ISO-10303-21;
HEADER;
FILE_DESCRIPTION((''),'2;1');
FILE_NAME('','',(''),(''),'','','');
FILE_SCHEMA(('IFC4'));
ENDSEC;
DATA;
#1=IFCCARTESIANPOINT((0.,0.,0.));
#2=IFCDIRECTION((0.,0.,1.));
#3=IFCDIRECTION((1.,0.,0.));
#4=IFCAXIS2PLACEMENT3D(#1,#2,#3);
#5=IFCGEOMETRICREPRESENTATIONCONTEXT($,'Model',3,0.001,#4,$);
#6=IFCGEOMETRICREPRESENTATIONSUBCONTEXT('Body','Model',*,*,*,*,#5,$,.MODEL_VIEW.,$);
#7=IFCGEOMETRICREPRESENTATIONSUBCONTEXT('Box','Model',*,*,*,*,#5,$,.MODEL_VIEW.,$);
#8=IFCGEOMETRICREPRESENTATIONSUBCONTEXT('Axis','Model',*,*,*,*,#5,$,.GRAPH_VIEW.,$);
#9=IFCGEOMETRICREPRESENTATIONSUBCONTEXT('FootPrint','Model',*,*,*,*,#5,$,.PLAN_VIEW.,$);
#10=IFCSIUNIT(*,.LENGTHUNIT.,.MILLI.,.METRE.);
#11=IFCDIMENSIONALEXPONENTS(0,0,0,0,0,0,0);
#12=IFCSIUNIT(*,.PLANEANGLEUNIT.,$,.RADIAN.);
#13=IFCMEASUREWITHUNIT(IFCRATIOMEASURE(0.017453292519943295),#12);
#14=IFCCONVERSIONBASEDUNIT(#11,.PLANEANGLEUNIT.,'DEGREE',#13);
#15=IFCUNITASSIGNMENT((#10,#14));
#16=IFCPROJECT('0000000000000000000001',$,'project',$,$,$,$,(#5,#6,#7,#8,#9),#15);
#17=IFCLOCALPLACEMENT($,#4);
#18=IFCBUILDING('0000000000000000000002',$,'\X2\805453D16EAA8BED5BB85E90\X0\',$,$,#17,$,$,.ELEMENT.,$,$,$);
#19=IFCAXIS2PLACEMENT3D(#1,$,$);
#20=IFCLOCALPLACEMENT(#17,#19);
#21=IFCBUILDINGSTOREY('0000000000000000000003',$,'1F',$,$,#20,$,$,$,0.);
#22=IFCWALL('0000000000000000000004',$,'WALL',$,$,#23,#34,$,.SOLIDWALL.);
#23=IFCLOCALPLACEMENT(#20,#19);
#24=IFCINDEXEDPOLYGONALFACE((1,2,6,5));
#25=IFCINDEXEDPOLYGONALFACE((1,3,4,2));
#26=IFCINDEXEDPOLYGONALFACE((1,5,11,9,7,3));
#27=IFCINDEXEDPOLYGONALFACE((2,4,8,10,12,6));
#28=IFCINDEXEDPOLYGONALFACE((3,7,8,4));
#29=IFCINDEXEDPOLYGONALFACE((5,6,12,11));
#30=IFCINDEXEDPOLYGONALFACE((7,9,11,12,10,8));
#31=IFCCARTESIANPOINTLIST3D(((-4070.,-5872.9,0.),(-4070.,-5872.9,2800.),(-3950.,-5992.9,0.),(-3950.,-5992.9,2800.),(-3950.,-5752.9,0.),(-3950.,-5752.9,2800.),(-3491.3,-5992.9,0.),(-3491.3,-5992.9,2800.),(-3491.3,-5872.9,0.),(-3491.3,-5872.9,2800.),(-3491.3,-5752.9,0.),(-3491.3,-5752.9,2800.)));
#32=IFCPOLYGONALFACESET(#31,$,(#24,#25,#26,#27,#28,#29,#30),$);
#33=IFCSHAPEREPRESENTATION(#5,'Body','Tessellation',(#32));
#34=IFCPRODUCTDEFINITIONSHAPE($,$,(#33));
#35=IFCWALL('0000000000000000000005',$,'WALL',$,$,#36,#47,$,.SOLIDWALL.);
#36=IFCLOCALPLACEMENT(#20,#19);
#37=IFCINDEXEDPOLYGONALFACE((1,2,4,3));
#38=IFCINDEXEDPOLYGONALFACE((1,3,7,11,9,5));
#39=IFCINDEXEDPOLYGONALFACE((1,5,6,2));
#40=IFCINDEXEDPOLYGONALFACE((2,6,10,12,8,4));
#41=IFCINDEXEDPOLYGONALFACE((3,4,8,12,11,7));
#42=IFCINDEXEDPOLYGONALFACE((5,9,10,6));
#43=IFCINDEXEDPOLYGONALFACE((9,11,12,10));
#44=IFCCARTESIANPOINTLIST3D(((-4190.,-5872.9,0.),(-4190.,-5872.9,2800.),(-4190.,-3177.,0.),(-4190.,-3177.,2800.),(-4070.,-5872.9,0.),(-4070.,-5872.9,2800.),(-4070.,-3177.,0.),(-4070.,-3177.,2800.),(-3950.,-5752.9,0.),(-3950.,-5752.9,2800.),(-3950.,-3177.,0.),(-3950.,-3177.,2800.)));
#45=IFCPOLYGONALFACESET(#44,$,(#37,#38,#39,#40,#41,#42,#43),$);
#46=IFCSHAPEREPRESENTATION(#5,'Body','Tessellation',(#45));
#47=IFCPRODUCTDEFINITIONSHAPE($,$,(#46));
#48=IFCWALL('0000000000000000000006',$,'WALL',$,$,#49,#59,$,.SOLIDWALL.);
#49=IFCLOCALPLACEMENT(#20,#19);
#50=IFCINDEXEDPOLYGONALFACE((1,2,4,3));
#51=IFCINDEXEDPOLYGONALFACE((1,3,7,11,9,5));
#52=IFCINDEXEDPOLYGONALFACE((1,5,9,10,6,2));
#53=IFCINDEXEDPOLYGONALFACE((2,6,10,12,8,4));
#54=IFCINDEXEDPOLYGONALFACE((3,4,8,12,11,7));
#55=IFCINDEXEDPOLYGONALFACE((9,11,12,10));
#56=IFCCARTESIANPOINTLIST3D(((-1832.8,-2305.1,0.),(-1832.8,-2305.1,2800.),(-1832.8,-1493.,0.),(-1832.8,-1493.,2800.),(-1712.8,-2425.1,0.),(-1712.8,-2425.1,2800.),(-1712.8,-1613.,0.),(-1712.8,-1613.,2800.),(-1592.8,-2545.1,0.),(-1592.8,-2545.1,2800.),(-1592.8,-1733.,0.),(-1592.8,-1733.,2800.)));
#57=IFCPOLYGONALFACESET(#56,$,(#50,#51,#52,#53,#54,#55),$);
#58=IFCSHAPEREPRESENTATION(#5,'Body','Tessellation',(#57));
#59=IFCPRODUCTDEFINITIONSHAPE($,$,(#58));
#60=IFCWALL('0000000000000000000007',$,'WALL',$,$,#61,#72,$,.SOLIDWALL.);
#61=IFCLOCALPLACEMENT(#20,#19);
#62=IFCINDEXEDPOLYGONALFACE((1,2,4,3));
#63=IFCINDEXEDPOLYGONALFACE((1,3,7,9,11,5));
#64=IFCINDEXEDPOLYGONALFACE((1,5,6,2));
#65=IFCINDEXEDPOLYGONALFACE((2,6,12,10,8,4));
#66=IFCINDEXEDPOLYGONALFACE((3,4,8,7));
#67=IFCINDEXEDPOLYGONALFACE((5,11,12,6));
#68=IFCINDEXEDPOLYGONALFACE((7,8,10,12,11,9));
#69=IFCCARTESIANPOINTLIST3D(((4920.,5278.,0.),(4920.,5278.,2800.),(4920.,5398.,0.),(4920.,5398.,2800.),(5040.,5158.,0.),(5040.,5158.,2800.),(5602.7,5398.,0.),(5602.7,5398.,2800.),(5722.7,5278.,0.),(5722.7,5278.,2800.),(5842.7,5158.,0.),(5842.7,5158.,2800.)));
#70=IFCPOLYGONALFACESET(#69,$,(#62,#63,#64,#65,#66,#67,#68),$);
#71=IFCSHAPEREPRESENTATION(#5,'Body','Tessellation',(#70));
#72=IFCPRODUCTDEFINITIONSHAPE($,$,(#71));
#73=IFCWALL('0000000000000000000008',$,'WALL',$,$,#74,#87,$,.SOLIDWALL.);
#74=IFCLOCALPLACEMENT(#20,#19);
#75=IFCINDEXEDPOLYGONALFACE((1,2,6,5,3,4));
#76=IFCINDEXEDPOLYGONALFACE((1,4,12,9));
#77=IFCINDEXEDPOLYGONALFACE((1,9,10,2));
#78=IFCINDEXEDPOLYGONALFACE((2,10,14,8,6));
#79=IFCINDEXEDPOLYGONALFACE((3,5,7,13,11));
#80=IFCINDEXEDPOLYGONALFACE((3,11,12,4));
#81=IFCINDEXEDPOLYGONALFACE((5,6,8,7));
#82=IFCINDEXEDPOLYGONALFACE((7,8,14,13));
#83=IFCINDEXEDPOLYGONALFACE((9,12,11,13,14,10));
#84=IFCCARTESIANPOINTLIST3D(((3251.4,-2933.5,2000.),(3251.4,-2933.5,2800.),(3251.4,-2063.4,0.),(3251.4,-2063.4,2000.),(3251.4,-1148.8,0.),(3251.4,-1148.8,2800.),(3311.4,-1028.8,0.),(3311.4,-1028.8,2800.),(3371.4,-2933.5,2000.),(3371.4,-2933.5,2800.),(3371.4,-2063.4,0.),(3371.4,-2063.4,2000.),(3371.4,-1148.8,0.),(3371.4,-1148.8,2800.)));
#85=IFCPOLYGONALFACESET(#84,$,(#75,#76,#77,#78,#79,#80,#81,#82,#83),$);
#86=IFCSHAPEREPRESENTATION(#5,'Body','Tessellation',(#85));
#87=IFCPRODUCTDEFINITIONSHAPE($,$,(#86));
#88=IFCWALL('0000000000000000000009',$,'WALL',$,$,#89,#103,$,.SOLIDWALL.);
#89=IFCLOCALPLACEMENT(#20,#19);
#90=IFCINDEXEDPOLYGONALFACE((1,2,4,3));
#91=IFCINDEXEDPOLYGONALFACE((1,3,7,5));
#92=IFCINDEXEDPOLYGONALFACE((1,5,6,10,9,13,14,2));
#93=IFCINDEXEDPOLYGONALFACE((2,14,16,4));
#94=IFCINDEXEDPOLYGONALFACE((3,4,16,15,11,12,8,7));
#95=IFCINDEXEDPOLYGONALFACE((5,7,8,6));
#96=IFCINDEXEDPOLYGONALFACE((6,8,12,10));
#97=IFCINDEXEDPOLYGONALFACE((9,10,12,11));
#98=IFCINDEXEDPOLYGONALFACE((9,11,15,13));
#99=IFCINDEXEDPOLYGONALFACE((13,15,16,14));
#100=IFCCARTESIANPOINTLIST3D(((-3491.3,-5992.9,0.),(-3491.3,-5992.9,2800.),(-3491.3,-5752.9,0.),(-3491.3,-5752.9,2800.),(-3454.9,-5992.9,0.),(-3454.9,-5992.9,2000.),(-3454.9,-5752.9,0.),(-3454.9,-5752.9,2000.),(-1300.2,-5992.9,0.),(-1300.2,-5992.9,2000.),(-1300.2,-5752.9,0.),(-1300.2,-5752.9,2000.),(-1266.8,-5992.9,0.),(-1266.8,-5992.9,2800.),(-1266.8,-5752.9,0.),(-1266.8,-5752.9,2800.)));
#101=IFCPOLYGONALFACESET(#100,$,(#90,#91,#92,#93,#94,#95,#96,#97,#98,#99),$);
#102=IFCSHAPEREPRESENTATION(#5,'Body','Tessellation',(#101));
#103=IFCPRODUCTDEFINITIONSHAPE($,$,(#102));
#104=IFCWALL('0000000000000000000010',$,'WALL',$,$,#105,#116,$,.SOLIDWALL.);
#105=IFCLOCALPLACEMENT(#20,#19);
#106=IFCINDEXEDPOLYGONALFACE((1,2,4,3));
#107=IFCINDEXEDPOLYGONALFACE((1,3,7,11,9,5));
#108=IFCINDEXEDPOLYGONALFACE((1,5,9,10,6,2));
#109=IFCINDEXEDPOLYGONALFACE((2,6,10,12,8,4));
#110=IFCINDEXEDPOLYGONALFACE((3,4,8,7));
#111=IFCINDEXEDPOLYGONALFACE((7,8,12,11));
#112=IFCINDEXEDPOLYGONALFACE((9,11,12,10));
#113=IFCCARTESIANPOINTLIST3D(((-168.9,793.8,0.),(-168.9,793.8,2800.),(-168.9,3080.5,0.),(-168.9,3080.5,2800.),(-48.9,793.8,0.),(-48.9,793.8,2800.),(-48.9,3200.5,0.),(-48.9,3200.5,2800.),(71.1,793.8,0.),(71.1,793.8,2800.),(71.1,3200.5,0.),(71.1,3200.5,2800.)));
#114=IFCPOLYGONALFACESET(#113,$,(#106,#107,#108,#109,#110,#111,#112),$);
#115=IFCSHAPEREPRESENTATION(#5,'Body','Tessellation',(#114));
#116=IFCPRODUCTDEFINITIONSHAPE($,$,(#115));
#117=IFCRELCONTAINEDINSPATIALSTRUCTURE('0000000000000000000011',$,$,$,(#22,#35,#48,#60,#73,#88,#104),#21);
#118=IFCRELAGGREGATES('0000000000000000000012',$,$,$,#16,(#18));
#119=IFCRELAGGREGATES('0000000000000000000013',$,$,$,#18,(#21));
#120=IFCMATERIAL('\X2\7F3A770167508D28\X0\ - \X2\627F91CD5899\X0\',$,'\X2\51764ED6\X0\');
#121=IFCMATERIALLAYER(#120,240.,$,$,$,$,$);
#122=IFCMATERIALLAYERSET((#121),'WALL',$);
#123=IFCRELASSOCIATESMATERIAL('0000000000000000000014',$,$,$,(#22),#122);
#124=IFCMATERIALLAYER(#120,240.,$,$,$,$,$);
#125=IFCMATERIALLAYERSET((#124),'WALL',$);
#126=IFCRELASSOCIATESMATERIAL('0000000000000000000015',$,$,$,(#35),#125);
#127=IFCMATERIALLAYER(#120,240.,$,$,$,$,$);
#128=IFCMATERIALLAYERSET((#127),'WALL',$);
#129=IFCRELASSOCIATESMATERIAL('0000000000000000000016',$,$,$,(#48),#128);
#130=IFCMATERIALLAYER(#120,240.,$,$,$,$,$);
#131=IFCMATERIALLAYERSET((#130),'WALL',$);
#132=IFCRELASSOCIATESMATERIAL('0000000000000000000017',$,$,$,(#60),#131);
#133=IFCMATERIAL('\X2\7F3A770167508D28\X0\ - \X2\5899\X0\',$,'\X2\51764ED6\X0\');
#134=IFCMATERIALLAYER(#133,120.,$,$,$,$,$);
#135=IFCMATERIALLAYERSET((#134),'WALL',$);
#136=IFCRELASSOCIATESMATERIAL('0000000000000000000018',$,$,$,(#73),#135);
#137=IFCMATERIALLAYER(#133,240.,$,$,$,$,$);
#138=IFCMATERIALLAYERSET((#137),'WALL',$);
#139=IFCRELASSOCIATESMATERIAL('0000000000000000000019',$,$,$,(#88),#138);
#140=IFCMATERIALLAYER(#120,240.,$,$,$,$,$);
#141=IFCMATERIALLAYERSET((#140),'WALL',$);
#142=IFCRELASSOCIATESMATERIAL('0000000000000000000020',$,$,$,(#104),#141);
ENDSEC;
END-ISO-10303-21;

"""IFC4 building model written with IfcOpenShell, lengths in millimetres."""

from ifc_helpers import new_model, entity, si_unit, converted_unit, origin, origin_with_axes, place, context, subcontext, project, spatial, polyline, segment, composite_curve, outline, extrude, material, layer, layer_set, layer_usage, element, save


model = new_model("IFC4")

# Units and contexts
model_context = context("Model", 3, precision=0.001, world=origin_with_axes())
body_context = subcontext(model_context, "Body", "Model", "MODEL_VIEW")
box_context = subcontext(model_context, "Box", "Model", "MODEL_VIEW")
axis_context = subcontext(model_context, "Axis", "Model", "GRAPH_VIEW")
footprint_context = subcontext(model_context, "FootPrint", "Model", "PLAN_VIEW")
ifc_project = project(units=[si_unit("LENGTHUNIT", "METRE", prefix="MILLI"), converted_unit("PLANEANGLEUNIT", "DEGREE", entity("IfcRatioMeasure", 0.017453292519943295), si_unit("PLANEANGLEUNIT", "RADIAN"), dimensions=[0, 0, 0, 0, 0, 0, 0])], contexts=[model_context, body_context, box_context, axis_context, footprint_context])

# Building, storey
building_placement = place(None, origin_with_axes())
building = spatial("IfcBuilding", under=ifc_project, at=building_placement, Name="联发溪语宸庐", CompositionType="ELEMENT")
storey_placement = place(building_placement, origin())
storey = spatial("IfcBuildingStorey", under=building, at=storey_placement, Name="1F", Elevation=0.0)

# Shared definitions
ifc_material_1 = material(Name="缺省材质 - 墙", Category="其他")

# Walls
ifc_material_2 = material(Name="缺省材质 - 承重墙", Category="其他")
ifc_layer_1 = layer(ifc_material_2, 240.0)
ifc_layer_set_1 = layer_set([ifc_layer_1], Name="WALL")
ifc_layer_usage_1 = layer_usage(ifc_layer_set_1, "AXIS2", "NEGATIVE", 120.0)
wall_1_placement = place(None, origin_with_axes())
element("IfcWall", 1, at=wall_1_placement, inside=storey, material=ifc_layer_usage_1, Name="WALL", PredefinedType="SOLIDWALL", context=model_context, shape_type="SweptSolid", body=[
    extrude(outline(composite_curve([segment(polyline([(-4070.0, -5872.9), (-3950.0, -5992.9)]), True, "CONTINUOUS"), segment(polyline([(-3950.0, -5992.9), (-3491.3, -5992.9)]), True, "CONTINUOUS"), segment(polyline([(-3491.3, -5992.9), (-3491.3, -5872.9)]), True, "CONTINUOUS"), segment(polyline([(-3491.3, -5872.9), (-3491.3, -5752.9)]), True, "CONTINUOUS"), segment(polyline([(-3491.3, -5752.9), (-3950.0, -5752.9)]), True, "CONTINUOUS"), segment(polyline([(-3950.0, -5752.9), (-4070.0, -5872.9)]), True, "CONTINUOUS")], self_intersect=False)), origin(), (0.0, 0.0, 1.0), 2800.0),
])
ifc_layer_2 = layer(ifc_material_2, 240.0)
ifc_layer_set_2 = layer_set([ifc_layer_2], Name="WALL")
ifc_layer_usage_2 = layer_usage(ifc_layer_set_2, "AXIS2", "NEGATIVE", 120.0)
wall_2_placement = place(None, origin_with_axes())
element("IfcWall", 2, at=wall_2_placement, inside=storey, material=ifc_layer_usage_2, Name="WALL", PredefinedType="SOLIDWALL", context=model_context, shape_type="SweptSolid", body=[
    extrude(outline(composite_curve([segment(polyline([(-4070.0, -3177.0), (-4190.0, -3177.0)]), True, "CONTINUOUS"), segment(polyline([(-4190.0, -3177.0), (-4190.0, -5872.9)]), True, "CONTINUOUS"), segment(polyline([(-4190.0, -5872.9), (-4070.0, -5872.9)]), True, "CONTINUOUS"), segment(polyline([(-4070.0, -5872.9), (-3950.0, -5752.9)]), True, "CONTINUOUS"), segment(polyline([(-3950.0, -5752.9), (-3950.0, -3177.0)]), True, "CONTINUOUS"), segment(polyline([(-3950.0, -3177.0), (-4070.0, -3177.0)]), True, "CONTINUOUS")], self_intersect=False)), origin(), (0.0, 0.0, 1.0), 2800.0),
])
ifc_layer_3 = layer(ifc_material_2, 240.0)
ifc_layer_set_3 = layer_set([ifc_layer_3], Name="WALL")
ifc_layer_usage_3 = layer_usage(ifc_layer_set_3, "AXIS2", "NEGATIVE", 120.0)
wall_3_placement = place(None, origin_with_axes())
element("IfcWall", 3, at=wall_3_placement, inside=storey, material=ifc_layer_usage_3, Name="WALL", PredefinedType="SOLIDWALL", context=model_context, shape_type="SweptSolid", body=[
    extrude(outline(composite_curve([segment(polyline([(-1712.8, -2425.1), (-1592.8, -2545.1)]), True, "CONTINUOUS"), segment(polyline([(-1592.8, -2545.1), (-1592.8, -1733.0)]), True, "CONTINUOUS"), segment(polyline([(-1592.8, -1733.0), (-1712.8, -1613.0)]), True, "CONTINUOUS"), segment(polyline([(-1712.8, -1613.0), (-1832.8, -1493.0)]), True, "CONTINUOUS"), segment(polyline([(-1832.8, -1493.0), (-1832.8, -2305.1)]), True, "CONTINUOUS"), segment(polyline([(-1832.8, -2305.1), (-1712.8, -2425.1)]), True, "CONTINUOUS")], self_intersect=False)), origin(), (0.0, 0.0, 1.0), 2800.0),
])
ifc_layer_4 = layer(ifc_material_2, 240.0)
ifc_layer_set_4 = layer_set([ifc_layer_4], Name="WALL")
ifc_layer_usage_4 = layer_usage(ifc_layer_set_4, "AXIS2", "NEGATIVE", 120.0)
wall_4_placement = place(None, origin_with_axes())
element("IfcWall", 4, at=wall_4_placement, inside=storey, material=ifc_layer_usage_4, Name="WALL", PredefinedType="SOLIDWALL", context=model_context, shape_type="SweptSolid", body=[
    extrude(outline(composite_curve([segment(polyline([(4920.0, 5278.0), (5040.0, 5158.0)]), True, "CONTINUOUS"), segment(polyline([(5040.0, 5158.0), (5842.7, 5158.0)]), True, "CONTINUOUS"), segment(polyline([(5842.7, 5158.0), (5722.7, 5278.0)]), True, "CONTINUOUS"), segment(polyline([(5722.7, 5278.0), (5602.7, 5398.0)]), True, "CONTINUOUS"), segment(polyline([(5602.7, 5398.0), (4920.0, 5398.0)]), True, "CONTINUOUS"), segment(polyline([(4920.0, 5398.0), (4920.0, 5278.0)]), True, "CONTINUOUS")], self_intersect=False)), origin(), (0.0, 0.0, 1.0), 2800.0),
])

# Walls, openings
ifc_layer_5 = layer(ifc_material_1, 120.0)
ifc_layer_set_5 = layer_set([ifc_layer_5], Name="WALL")
ifc_layer_usage_5 = layer_usage(ifc_layer_set_5, "AXIS2", "NEGATIVE", 60.0)
wall_5_placement = place(None, origin_with_axes())
wall_5 = element("IfcWall", 5, at=wall_5_placement, inside=storey, material=ifc_layer_usage_5, Name="WALL", PredefinedType="SOLIDWALL", context=model_context, shape_type="SweptSolid", body=[
    extrude(outline(composite_curve([segment(polyline([(3311.4, -1028.8), (3251.4, -1148.8)]), True, "CONTINUOUS"), segment(polyline([(3251.4, -1148.8), (3251.4, -2933.5)]), True, "CONTINUOUS"), segment(polyline([(3251.4, -2933.5), (3311.4, -2933.5)]), True, "CONTINUOUS"), segment(polyline([(3311.4, -2933.5), (3371.4, -2933.5)]), True, "CONTINUOUS"), segment(polyline([(3371.4, -2933.5), (3371.4, -1148.8)]), True, "CONTINUOUS"), segment(polyline([(3371.4, -1148.8), (3311.4, -1028.8)]), True, "CONTINUOUS")], self_intersect=False)), origin(), (0.0, 0.0, 1.0), 2800.0),
])
opening_1_placement = place(None, origin_with_axes())
element("IfcOpeningElement", 6, at=opening_1_placement, cuts=wall_5, ObjectType="OPENING", PredefinedType="OPENING", context=model_context, shape_type="SweptSolid", body=[
    extrude(outline(composite_curve([segment(polyline([(3371.4, -2933.5), (3371.4, -2063.4)]), True, "CONTINUOUS"), segment(polyline([(3371.4, -2063.4), (3251.4, -2063.4)]), True, "CONTINUOUS"), segment(polyline([(3251.4, -2063.4), (3251.4, -2933.5)]), True, "CONTINUOUS"), segment(polyline([(3251.4, -2933.5), (3371.4, -2933.5)]), True, "CONTINUOUS")], self_intersect=False)), origin_with_axes(), (0.0, 0.0, 1.0), 2000.0),
])
ifc_layer_6 = layer(ifc_material_1, 240.0)
ifc_layer_set_6 = layer_set([ifc_layer_6], Name="WALL")
ifc_layer_usage_6 = layer_usage(ifc_layer_set_6, "AXIS2", "NEGATIVE", 120.0)
wall_6_placement = place(None, origin_with_axes())
wall_6 = element("IfcWall", 7, at=wall_6_placement, inside=storey, material=ifc_layer_usage_6, Name="WALL", PredefinedType="SOLIDWALL", context=model_context, shape_type="SweptSolid", body=[
    extrude(outline(composite_curve([segment(polyline([(-3491.3, -5872.9), (-3491.3, -5992.9)]), True, "CONTINUOUS"), segment(polyline([(-3491.3, -5992.9), (-1266.8, -5992.9)]), True, "CONTINUOUS"), segment(polyline([(-1266.8, -5992.9), (-1266.8, -5872.9)]), True, "CONTINUOUS"), segment(polyline([(-1266.8, -5872.9), (-1266.8, -5752.9)]), True, "CONTINUOUS"), segment(polyline([(-1266.8, -5752.9), (-3491.3, -5752.9)]), True, "CONTINUOUS"), segment(polyline([(-3491.3, -5752.9), (-3491.3, -5872.9)]), True, "CONTINUOUS")], self_intersect=False)), origin(), (0.0, 0.0, 1.0), 2800.0),
])
opening_2_placement = place(None, origin_with_axes())
element("IfcOpeningElement", 8, at=opening_2_placement, cuts=wall_6, ObjectType="OPENING", PredefinedType="OPENING", context=model_context, shape_type="SweptSolid", body=[
    extrude(outline(composite_curve([segment(polyline([(-1300.2, -5752.9), (-3454.9, -5752.9)]), True, "CONTINUOUS"), segment(polyline([(-3454.9, -5752.9), (-3454.9, -5992.9)]), True, "CONTINUOUS"), segment(polyline([(-3454.9, -5992.9), (-1300.2, -5992.9)]), True, "CONTINUOUS"), segment(polyline([(-1300.2, -5992.9), (-1300.2, -5752.9)]), True, "CONTINUOUS")], self_intersect=False)), origin_with_axes(), (0.0, 0.0, 1.0), 2000.0),
])

# Wall
ifc_layer_7 = layer(ifc_material_2, 240.0)
ifc_layer_set_7 = layer_set([ifc_layer_7], Name="WALL")
ifc_layer_usage_7 = layer_usage(ifc_layer_set_7, "AXIS2", "NEGATIVE", 120.0)
wall_7_placement = place(None, origin_with_axes())
element("IfcWall", 9, at=wall_7_placement, inside=storey, material=ifc_layer_usage_7, Name="WALL", PredefinedType="SOLIDWALL", context=model_context, shape_type="SweptSolid", body=[
    extrude(outline(composite_curve([segment(polyline([(-48.9, 793.8), (71.1, 793.8)]), True, "CONTINUOUS"), segment(polyline([(71.1, 793.8), (71.1, 3200.5)]), True, "CONTINUOUS"), segment(polyline([(71.1, 3200.5), (-48.9, 3200.5)]), True, "CONTINUOUS"), segment(polyline([(-48.9, 3200.5), (-168.9, 3080.5)]), True, "CONTINUOUS"), segment(polyline([(-168.9, 3080.5), (-168.9, 793.8)]), True, "CONTINUOUS"), segment(polyline([(-168.9, 793.8), (-48.9, 793.8)]), True, "CONTINUOUS")], self_intersect=False)), origin(), (0.0, 0.0, 1.0), 2800.0),
])

save(model, "model.ifc")
